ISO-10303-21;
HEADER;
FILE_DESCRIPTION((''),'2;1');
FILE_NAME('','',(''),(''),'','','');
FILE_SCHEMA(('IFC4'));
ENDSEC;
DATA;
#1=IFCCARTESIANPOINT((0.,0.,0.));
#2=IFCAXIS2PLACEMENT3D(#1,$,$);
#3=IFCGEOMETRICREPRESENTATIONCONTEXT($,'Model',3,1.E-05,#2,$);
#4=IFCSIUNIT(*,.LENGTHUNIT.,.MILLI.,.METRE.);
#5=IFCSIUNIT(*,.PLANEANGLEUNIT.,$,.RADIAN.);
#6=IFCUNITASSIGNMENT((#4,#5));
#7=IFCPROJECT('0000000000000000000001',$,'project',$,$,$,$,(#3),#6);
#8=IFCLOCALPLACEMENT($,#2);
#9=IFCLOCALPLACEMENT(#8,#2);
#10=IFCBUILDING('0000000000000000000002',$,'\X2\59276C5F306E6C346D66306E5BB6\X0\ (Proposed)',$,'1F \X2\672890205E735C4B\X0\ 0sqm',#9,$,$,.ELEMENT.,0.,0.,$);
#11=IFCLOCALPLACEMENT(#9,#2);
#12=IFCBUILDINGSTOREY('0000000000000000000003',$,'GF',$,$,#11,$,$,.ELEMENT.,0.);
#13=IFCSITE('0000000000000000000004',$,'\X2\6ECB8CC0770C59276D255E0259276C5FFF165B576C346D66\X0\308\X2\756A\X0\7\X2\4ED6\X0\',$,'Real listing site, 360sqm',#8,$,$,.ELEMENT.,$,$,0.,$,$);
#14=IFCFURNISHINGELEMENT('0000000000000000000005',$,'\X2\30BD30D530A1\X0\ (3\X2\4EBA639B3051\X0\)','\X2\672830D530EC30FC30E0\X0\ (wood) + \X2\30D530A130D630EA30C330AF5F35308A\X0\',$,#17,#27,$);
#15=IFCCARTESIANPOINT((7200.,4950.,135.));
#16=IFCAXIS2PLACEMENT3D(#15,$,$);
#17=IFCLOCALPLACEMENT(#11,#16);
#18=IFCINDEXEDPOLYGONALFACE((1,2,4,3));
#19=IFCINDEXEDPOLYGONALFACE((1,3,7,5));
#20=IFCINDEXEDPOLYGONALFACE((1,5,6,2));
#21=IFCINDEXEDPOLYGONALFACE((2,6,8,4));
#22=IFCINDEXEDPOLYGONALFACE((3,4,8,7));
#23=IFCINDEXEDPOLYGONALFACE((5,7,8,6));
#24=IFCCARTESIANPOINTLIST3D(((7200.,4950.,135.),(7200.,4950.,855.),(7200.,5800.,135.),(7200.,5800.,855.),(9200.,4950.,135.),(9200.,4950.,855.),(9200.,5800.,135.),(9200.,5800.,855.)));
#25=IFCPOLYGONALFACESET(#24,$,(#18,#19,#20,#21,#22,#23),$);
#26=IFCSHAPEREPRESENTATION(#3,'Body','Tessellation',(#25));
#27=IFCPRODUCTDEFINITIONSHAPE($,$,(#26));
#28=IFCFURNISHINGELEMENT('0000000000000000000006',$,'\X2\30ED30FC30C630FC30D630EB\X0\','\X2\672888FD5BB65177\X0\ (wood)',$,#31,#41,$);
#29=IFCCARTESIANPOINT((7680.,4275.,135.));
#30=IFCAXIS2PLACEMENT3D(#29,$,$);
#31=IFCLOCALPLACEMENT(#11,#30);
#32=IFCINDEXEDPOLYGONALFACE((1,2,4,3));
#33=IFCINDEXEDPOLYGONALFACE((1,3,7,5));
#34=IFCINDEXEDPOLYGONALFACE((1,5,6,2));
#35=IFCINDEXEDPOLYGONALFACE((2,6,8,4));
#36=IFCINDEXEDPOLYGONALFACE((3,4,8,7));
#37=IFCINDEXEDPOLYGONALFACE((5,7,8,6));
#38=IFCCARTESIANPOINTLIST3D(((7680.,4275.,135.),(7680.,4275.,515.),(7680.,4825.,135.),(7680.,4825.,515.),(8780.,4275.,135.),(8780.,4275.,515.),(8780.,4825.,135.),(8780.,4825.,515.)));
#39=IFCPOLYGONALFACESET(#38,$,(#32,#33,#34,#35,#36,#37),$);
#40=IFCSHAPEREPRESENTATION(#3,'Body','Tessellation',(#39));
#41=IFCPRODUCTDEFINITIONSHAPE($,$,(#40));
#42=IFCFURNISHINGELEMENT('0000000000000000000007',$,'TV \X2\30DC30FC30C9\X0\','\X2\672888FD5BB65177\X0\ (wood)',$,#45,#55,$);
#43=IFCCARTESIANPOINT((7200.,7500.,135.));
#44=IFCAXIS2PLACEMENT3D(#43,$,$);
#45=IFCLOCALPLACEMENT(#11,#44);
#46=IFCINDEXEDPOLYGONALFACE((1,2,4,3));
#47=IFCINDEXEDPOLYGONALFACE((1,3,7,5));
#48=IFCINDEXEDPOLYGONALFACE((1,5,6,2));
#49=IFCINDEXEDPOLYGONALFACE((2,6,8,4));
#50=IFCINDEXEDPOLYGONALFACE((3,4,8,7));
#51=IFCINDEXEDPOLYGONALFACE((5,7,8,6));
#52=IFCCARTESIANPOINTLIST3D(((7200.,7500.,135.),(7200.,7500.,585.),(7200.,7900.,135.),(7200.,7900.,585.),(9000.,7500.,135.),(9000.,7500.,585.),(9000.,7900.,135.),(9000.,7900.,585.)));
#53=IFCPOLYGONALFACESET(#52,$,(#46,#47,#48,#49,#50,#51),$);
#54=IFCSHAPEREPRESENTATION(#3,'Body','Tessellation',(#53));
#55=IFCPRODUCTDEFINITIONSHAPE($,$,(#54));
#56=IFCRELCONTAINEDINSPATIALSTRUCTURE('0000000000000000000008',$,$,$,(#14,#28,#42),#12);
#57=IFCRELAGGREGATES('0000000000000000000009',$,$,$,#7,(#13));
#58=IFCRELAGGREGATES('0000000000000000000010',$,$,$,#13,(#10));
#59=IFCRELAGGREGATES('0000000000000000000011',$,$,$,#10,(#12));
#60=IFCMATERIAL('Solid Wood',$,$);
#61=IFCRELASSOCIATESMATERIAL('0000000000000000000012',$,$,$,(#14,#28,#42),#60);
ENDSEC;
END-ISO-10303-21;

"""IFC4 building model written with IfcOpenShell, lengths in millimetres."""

from ifc_helpers import new_model, si_unit, frame, frame_2d, origin, place, context, project, spatial, rectangle, extrude, material, element, save


model = new_model("IFC4")

# Units and contexts
model_context = context("Model", 3, precision=1e-05, world=origin())
ifc_project = project(units=[si_unit("LENGTHUNIT", "METRE", prefix="MILLI"), si_unit("PLANEANGLEUNIT", "RADIAN")], contexts=[model_context])

# Site, building, storey
site_placement = place(None, origin())
site = spatial("IfcSite", under=ifc_project, at=site_placement, Name="滋賀県大津市大江６字水浦308番7他", ObjectType="Real listing site, 360sqm", CompositionType="ELEMENT", RefElevation=0.0)
building_placement = place(site_placement, origin())
building = spatial("IfcBuilding", under=site, at=building_placement, Name="大江の水浦の家 (Proposed)", ObjectType="1F 木造平屋 0sqm", CompositionType="ELEMENT", ElevationOfRefHeight=0.0, ElevationOfTerrain=0.0)
storey_placement = place(building_placement, origin())
storey = spatial("IfcBuildingStorey", under=building, at=storey_placement, Name="GF", CompositionType="ELEMENT", Elevation=0.0)

# Shared definitions
ifc_material_1 = material(Name="Solid Wood")

# Furnishing elements
furnishing_1_placement = place(storey_placement, frame((7200.0, 4950.0, 135.0)))
element("IfcFurnishingElement", 1, at=furnishing_1_placement, inside=storey, material=ifc_material_1, Name="ソファ (3人掛け)", Description="木フレーム (wood) + ファブリック張り", context=model_context, shape_type="SweptSolid", body=[
    extrude(rectangle(XDim=2000.0, YDim=850.0, at=frame_2d((1000.0, 425.0))), frame((7200.0, 4950.0, 135.0)), (0.0, 0.0, 1.0), 720.0),
])
furnishing_2_placement = place(storey_placement, frame((7680.0, 4275.0, 135.0)))
element("IfcFurnishingElement", 2, at=furnishing_2_placement, inside=storey, material=ifc_material_1, Name="ローテーブル", Description="木製家具 (wood)", context=model_context, shape_type="SweptSolid", body=[
    extrude(rectangle(XDim=1100.0, YDim=550.0, at=frame_2d((550.0, 275.0))), frame((7680.0, 4275.0, 135.0)), (0.0, 0.0, 1.0), 380.0),
])
furnishing_3_placement = place(storey_placement, frame((7200.0, 7500.0, 135.0)))
element("IfcFurnishingElement", 3, at=furnishing_3_placement, inside=storey, material=ifc_material_1, Name="TV ボード", Description="木製家具 (wood)", context=model_context, shape_type="SweptSolid", body=[
    extrude(rectangle(XDim=1800.0, YDim=400.0, at=frame_2d((900.0, 200.0))), frame((7200.0, 7500.0, 135.0)), (0.0, 0.0, 1.0), 450.0),
])

save(model, "model.ifc")
